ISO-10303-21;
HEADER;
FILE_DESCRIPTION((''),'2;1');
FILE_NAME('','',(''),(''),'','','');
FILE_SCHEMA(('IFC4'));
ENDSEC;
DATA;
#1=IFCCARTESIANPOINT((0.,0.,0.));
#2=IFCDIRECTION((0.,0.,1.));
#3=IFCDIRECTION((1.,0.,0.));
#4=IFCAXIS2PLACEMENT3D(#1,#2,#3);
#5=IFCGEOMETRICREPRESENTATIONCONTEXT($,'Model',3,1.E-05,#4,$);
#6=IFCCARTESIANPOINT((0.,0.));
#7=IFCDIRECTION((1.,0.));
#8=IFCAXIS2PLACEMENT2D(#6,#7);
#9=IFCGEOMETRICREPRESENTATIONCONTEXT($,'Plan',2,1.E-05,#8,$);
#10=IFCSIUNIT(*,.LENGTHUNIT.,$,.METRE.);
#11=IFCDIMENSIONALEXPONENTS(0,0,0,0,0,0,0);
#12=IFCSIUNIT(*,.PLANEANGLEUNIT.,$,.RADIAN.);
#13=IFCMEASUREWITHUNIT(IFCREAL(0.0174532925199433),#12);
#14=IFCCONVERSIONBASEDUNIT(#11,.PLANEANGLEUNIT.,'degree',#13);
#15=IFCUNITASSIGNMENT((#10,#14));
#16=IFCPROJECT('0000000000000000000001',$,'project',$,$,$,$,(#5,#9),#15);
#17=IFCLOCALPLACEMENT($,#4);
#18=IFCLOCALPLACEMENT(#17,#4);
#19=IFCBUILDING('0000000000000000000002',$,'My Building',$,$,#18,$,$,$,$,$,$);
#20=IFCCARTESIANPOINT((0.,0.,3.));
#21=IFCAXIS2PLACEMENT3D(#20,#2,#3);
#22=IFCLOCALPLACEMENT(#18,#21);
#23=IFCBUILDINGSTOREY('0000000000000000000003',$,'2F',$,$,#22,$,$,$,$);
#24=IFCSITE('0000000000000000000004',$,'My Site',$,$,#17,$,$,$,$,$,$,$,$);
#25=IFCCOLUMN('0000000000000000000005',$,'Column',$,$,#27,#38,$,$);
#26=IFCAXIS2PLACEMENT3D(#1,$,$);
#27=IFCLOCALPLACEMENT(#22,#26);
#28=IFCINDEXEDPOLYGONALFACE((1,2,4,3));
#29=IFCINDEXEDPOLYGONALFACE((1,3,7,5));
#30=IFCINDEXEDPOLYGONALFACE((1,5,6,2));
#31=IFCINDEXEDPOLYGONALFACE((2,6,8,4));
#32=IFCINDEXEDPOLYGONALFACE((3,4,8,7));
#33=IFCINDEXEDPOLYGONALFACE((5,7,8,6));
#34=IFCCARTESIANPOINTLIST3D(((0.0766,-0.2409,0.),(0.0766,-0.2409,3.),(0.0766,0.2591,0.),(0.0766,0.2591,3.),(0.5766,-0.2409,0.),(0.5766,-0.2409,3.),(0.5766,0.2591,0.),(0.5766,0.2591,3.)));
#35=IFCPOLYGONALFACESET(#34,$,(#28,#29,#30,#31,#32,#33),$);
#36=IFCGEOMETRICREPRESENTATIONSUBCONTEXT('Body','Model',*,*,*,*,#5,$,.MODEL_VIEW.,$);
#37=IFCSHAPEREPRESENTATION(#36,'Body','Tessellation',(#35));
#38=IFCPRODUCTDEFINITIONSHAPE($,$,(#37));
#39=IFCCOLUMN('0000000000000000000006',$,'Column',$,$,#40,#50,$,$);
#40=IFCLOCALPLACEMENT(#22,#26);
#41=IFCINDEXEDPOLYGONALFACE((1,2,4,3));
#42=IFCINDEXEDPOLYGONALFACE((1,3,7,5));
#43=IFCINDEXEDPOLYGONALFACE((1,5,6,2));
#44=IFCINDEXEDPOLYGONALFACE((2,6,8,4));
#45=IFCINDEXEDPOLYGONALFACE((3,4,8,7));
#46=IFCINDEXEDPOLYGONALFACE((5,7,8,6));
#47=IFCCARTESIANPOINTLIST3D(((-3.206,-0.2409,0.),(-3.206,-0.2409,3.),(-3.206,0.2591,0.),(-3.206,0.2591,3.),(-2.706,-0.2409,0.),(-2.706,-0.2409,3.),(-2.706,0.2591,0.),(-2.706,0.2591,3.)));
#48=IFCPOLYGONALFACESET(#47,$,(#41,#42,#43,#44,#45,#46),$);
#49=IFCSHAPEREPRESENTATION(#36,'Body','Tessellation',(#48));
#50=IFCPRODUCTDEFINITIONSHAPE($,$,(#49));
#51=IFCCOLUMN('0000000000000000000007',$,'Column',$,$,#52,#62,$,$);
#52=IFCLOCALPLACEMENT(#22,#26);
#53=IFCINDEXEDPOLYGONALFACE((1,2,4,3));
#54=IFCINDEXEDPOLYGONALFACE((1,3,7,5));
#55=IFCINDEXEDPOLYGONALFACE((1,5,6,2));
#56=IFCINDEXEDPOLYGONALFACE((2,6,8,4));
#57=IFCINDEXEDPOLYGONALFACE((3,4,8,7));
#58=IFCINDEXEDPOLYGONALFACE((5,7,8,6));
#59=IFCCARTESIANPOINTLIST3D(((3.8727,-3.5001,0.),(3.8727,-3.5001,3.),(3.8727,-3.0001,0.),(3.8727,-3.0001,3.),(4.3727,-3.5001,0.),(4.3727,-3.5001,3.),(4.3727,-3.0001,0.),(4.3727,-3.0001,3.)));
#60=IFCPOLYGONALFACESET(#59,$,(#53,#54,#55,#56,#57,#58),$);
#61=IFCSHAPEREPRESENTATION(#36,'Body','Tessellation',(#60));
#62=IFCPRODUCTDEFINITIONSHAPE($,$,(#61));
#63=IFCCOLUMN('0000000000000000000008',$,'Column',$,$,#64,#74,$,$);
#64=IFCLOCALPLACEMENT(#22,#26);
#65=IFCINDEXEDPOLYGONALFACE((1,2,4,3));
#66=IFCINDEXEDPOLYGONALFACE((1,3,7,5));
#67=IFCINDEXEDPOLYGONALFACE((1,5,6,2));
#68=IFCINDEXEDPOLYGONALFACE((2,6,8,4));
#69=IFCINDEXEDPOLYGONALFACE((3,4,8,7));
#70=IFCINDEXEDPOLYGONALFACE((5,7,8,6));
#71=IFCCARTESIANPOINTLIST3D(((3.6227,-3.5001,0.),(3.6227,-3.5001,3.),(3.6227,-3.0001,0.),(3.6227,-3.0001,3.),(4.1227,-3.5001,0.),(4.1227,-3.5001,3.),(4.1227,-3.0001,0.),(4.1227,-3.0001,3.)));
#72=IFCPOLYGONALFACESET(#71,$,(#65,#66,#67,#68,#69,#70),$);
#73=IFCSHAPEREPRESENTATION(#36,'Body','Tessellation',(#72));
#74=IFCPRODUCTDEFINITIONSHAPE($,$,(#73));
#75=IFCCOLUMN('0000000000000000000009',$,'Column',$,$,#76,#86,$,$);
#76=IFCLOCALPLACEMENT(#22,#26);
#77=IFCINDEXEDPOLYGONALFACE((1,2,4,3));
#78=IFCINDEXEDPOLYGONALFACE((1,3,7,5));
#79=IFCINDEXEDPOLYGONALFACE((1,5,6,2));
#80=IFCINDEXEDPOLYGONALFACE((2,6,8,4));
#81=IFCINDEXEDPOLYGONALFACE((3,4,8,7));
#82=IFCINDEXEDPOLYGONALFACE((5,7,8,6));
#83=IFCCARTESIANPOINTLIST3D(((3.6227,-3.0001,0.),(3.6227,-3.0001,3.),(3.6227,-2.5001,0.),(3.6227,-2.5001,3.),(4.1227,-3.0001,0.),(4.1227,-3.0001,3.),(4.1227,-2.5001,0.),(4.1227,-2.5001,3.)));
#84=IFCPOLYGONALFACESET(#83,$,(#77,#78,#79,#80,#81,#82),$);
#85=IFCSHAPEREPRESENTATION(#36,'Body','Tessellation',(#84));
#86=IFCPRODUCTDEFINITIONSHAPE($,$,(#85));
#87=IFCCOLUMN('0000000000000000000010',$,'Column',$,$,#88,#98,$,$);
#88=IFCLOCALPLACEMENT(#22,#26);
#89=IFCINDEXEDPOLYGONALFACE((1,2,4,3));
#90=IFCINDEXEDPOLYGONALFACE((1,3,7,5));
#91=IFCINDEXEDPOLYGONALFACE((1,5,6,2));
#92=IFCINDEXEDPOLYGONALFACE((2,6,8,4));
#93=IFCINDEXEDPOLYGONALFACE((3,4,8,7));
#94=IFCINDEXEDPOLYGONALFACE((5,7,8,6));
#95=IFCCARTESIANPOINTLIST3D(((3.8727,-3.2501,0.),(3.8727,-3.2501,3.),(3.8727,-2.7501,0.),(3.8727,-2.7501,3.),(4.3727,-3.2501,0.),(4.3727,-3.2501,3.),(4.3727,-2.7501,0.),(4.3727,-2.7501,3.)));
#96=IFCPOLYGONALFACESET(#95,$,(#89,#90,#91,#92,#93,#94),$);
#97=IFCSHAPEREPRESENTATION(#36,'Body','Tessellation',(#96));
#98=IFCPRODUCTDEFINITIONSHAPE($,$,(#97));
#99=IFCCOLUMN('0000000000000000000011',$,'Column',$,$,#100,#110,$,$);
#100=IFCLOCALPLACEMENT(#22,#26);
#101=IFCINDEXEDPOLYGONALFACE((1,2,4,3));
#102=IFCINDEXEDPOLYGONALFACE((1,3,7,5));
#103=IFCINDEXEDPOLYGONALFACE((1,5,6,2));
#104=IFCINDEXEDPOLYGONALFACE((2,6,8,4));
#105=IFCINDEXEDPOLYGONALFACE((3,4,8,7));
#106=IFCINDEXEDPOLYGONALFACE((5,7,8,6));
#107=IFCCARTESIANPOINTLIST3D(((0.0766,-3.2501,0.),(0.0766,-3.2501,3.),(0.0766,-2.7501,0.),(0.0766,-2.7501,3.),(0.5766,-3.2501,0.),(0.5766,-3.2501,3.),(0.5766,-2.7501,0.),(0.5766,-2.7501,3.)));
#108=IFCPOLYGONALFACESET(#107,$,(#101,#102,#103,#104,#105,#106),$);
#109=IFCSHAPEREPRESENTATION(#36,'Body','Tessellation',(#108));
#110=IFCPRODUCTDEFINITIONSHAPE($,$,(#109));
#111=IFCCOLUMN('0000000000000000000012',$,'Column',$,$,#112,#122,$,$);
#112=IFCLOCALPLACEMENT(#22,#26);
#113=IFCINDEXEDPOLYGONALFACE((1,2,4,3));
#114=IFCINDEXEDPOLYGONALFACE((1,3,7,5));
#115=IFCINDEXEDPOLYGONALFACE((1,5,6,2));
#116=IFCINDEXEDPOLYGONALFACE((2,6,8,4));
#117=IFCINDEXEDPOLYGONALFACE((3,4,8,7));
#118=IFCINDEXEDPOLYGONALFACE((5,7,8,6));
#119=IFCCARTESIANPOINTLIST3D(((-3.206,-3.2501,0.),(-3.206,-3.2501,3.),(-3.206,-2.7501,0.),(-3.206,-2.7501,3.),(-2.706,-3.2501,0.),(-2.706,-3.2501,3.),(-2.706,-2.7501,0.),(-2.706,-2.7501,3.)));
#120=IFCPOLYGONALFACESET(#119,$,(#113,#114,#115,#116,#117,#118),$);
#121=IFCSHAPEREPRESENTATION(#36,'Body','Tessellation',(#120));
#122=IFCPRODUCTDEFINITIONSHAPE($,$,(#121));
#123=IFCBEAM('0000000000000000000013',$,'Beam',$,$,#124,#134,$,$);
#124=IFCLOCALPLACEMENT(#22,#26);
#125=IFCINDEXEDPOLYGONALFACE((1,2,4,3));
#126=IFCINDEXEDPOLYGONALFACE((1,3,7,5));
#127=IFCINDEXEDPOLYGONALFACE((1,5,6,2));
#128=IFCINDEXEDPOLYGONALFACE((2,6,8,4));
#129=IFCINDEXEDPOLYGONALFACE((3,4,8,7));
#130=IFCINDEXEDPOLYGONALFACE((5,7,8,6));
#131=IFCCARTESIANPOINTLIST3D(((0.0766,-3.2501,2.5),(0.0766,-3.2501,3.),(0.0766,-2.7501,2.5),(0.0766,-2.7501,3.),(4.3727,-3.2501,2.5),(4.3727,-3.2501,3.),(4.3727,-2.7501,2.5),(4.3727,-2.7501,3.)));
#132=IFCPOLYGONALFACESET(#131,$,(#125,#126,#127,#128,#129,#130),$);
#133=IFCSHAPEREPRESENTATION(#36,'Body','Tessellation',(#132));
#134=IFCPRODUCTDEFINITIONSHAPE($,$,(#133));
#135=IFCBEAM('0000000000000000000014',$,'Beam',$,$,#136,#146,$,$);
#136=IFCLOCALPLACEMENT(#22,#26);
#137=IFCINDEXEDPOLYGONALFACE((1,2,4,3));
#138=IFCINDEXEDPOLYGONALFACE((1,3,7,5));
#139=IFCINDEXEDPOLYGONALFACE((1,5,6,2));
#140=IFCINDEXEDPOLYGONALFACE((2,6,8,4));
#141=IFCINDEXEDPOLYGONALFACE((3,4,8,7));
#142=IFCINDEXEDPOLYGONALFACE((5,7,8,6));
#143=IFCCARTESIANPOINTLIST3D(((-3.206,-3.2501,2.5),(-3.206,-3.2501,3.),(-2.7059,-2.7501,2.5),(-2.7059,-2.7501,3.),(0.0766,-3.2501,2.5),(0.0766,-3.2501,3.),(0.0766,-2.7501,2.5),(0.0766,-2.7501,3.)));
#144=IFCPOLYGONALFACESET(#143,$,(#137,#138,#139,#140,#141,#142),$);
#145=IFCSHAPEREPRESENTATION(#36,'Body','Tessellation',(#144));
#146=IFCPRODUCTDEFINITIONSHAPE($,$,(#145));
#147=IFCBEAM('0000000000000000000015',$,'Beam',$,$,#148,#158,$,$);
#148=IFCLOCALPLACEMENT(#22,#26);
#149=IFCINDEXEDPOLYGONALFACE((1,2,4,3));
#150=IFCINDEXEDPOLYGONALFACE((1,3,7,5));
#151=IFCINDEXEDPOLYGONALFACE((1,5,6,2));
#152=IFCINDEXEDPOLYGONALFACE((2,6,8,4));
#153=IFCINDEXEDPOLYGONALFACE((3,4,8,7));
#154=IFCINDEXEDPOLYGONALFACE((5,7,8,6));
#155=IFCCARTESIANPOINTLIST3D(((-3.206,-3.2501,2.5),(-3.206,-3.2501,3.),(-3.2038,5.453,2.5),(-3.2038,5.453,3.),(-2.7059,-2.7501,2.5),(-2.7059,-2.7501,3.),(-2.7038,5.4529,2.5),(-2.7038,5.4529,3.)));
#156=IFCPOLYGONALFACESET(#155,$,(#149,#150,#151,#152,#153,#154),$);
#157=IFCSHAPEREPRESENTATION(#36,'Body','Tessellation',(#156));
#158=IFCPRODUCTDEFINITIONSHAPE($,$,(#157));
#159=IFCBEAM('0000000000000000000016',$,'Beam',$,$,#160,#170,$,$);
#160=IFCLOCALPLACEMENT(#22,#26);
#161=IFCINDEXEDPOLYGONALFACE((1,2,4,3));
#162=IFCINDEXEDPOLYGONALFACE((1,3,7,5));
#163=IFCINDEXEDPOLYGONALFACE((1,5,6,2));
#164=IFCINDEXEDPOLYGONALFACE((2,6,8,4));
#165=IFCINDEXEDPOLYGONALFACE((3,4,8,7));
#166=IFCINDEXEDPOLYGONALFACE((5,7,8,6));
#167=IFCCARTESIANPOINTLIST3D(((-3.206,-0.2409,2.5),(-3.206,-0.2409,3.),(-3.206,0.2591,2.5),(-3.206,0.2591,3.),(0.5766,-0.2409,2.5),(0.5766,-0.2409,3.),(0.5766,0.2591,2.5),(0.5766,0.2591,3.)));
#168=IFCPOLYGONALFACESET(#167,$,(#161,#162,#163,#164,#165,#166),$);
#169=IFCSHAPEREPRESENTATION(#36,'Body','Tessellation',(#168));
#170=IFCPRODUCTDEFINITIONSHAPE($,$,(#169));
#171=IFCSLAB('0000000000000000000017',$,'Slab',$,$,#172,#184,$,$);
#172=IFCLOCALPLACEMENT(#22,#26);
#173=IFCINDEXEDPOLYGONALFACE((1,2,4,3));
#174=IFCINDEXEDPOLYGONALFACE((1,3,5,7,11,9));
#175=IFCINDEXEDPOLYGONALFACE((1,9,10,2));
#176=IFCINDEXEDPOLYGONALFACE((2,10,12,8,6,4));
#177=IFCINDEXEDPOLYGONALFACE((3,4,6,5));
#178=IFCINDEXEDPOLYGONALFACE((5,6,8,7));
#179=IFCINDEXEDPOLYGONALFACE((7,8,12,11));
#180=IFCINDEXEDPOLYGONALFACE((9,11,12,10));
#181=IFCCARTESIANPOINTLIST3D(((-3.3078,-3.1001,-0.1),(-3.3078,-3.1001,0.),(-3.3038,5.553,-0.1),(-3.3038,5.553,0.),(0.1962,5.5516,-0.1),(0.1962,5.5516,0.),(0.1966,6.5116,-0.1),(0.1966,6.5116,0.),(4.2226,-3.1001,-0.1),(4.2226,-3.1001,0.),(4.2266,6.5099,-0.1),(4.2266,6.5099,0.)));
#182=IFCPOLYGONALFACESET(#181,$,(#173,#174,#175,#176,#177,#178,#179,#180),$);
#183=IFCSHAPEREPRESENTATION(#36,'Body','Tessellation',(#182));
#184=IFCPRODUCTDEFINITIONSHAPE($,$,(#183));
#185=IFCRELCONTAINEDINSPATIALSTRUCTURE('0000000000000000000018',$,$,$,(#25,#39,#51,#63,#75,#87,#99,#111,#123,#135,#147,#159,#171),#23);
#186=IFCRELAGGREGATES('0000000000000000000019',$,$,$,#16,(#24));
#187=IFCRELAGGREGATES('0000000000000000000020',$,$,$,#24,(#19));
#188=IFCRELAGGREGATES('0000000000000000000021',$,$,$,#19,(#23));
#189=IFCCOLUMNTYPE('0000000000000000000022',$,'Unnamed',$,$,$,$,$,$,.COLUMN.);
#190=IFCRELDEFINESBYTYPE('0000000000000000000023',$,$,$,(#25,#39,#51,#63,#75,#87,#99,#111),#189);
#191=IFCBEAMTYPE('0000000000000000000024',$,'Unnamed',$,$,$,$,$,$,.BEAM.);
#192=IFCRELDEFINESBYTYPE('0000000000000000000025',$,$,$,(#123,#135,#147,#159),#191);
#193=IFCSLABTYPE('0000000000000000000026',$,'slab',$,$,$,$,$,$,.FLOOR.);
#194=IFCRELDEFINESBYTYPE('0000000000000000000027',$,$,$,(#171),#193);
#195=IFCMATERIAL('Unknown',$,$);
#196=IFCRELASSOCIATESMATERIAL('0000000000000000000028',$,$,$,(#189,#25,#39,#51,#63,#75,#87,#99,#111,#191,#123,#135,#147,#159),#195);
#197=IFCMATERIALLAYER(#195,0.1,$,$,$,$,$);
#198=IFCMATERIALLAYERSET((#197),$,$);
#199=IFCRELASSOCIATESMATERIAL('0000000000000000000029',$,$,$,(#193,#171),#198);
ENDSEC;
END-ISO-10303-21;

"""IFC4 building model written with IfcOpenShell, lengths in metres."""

from ifc_helpers import new_model, entity, si_unit, converted_unit, frame, origin_with_axes, origin_2d_with_axis, place, context, subcontext, project, spatial, indexed_curve, rectangle, outline, extrude, clip, halfspace, material, layer, layer_set, layer_usage, material_profile, profile_set, profile_usage, type_object, element, save


model = new_model("IFC4")

# Units and contexts
model_context = context("Model", 3, precision=1e-05, world=origin_with_axes())
plan_context = context("Plan", 2, precision=1e-05, world=origin_2d_with_axis())
body_context_1 = subcontext(model_context, "Body", "Model", "MODEL_VIEW")
ifc_project = project(units=[si_unit("LENGTHUNIT", "METRE"), converted_unit("PLANEANGLEUNIT", "degree", entity("IfcReal", 0.0174532925199433), si_unit("PLANEANGLEUNIT", "RADIAN"), dimensions=[0, 0, 0, 0, 0, 0, 0])], contexts=[model_context, plan_context])

# Site, building, storey
site_placement = place(None, origin_with_axes())
site = spatial("IfcSite", under=ifc_project, at=site_placement, Name="My Site")
building_placement = place(site_placement, origin_with_axes())
building = spatial("IfcBuilding", under=site, at=building_placement, Name="My Building")
storey_placement = place(building_placement, frame((0.0, 0.0, 3.0), z_axis=(0.0, 0.0, 1.0), x_axis=(1.0, 0.0, 0.0)))
storey = spatial("IfcBuildingStorey", under=building, at=storey_placement, Name="2F")

# Columns
ifc_material = material(Name="Unknown")
ifc_material_profile_1 = material_profile(ifc_material, rectangle(XDim=0.5, YDim=0.5))
ifc_profile_set_1 = profile_set([ifc_material_profile_1])
ifc_profile_usage_1 = profile_usage(ifc_profile_set_1, cardinal=9)
column_type = type_object("IfcColumnType", Name="Unnamed", PredefinedType="COLUMN", material=ifc_profile_set_1)
column_1_placement = place(storey_placement, frame((0.0766, 0.2591, 0.0), z_axis=(0.0, 0.0, 1.0), x_axis=(1.0, 0.0, 0.0)))
element("IfcColumn", 1, at=column_1_placement, inside=storey, type_object=column_type, material=ifc_profile_usage_1, Name="Column", context=body_context_1, shape_type="SweptSolid", body=[
    extrude(rectangle(XDim=0.5, YDim=0.5), frame((0.25, -0.25, 0.0), z_axis=(0.0, 0.0, 1.0), x_axis=(1.0, 0.0, 0.0)), (0.0, 0.0, 1.0), 3.0),
])
ifc_profile_usage_2 = profile_usage(ifc_profile_set_1, cardinal=9)
column_2_placement = place(storey_placement, frame((-3.206, 0.2591, 0.0), z_axis=(0.0, 0.0, 1.0), x_axis=(1.0, 0.0, 0.0)))
element("IfcColumn", 2, at=column_2_placement, inside=storey, type_object=column_type, material=ifc_profile_usage_2, Name="Column", context=body_context_1, shape_type="SweptSolid", body=[
    extrude(rectangle(XDim=0.5, YDim=0.5), frame((0.25, -0.25, 0.0), z_axis=(0.0, 0.0, 1.0), x_axis=(1.0, 0.0, 0.0)), (0.0, 0.0, 1.0), 3.0),
])
ifc_profile_usage_3 = profile_usage(ifc_profile_set_1, cardinal=8)
column_3_placement = place(storey_placement, frame((4.1227, -3.0001, 0.0), z_axis=(0.0, 0.0, 1.0), x_axis=(1.0, 0.0, 0.0)))
element("IfcColumn", 3, at=column_3_placement, inside=storey, type_object=column_type, material=ifc_profile_usage_3, Name="Column", context=body_context_1, shape_type="SweptSolid", body=[
    extrude(rectangle(XDim=0.5, YDim=0.5), frame((0.0, -0.25, 0.0), z_axis=(0.0, 0.0, 1.0), x_axis=(1.0, 0.0, 0.0)), (0.0, 0.0, 1.0), 3.0),
])
ifc_profile_usage_4 = profile_usage(ifc_profile_set_1, cardinal=7)
column_4_placement = place(storey_placement, frame((4.1227, -3.0001, 0.0), z_axis=(0.0, 0.0, 1.0), x_axis=(1.0, 0.0, 0.0)))
element("IfcColumn", 4, at=column_4_placement, inside=storey, type_object=column_type, material=ifc_profile_usage_4, Name="Column", context=body_context_1, shape_type="SweptSolid", body=[
    extrude(rectangle(XDim=0.5, YDim=0.5), frame((-0.25, -0.25, 0.0), z_axis=(0.0, 0.0, 1.0), x_axis=(1.0, 0.0, 0.0)), (0.0, 0.0, 1.0), 3.0),
])
ifc_profile_usage_5 = profile_usage(ifc_profile_set_1, cardinal=1)
column_5_placement = place(storey_placement, frame((4.1227, -3.0001, 0.0), z_axis=(0.0, 0.0, 1.0), x_axis=(1.0, 0.0, 0.0)))
element("IfcColumn", 5, at=column_5_placement, inside=storey, type_object=column_type, material=ifc_profile_usage_5, Name="Column", context=body_context_1, shape_type="SweptSolid", body=[
    extrude(rectangle(XDim=0.5, YDim=0.5), frame((-0.25, 0.25, 0.0), z_axis=(0.0, 0.0, 1.0), x_axis=(1.0, 0.0, 0.0)), (0.0, 0.0, 1.0), 3.0),
])
ifc_profile_usage_6 = profile_usage(ifc_profile_set_1, cardinal=5)
column_6_placement = place(storey_placement, frame((4.1227, -3.0001, 0.0), z_axis=(0.0, 0.0, 1.0), x_axis=(1.0, 0.0, 0.0)))
element("IfcColumn", 6, at=column_6_placement, inside=storey, type_object=column_type, material=ifc_profile_usage_6, Name="Column", context=body_context_1, shape_type="SweptSolid", body=[
    extrude(rectangle(XDim=0.5, YDim=0.5), origin_with_axes(), (0.0, 0.0, 1.0), 3.0),
])
ifc_profile_usage_7 = profile_usage(ifc_profile_set_1, cardinal=5)
column_7_placement = place(storey_placement, frame((0.3266, -3.0001, 0.0), z_axis=(0.0, 0.0, 1.0), x_axis=(1.0, 0.0, 0.0)))
element("IfcColumn", 7, at=column_7_placement, inside=storey, type_object=column_type, material=ifc_profile_usage_7, Name="Column", context=body_context_1, shape_type="SweptSolid", body=[
    extrude(rectangle(XDim=0.5, YDim=0.5), origin_with_axes(), (0.0, 0.0, 1.0), 3.0),
])
ifc_profile_usage_8 = profile_usage(ifc_profile_set_1, cardinal=5)
column_8_placement = place(storey_placement, frame((-2.956, -3.0001, 0.0), z_axis=(0.0, 0.0, 1.0), x_axis=(1.0, 0.0, 0.0)))
element("IfcColumn", 8, at=column_8_placement, inside=storey, type_object=column_type, material=ifc_profile_usage_8, Name="Column", context=body_context_1, shape_type="SweptSolid", body=[
    extrude(rectangle(XDim=0.5, YDim=0.5), origin_with_axes(), (0.0, 0.0, 1.0), 3.0),
])

# Beams
ifc_material_profile_2 = material_profile(ifc_material, rectangle(XDim=0.5, YDim=0.5))
ifc_profile_set_2 = profile_set([ifc_material_profile_2])
ifc_profile_usage_9 = profile_usage(ifc_profile_set_2, cardinal=7)
beam_type = type_object("IfcBeamType", Name="Unnamed", PredefinedType="BEAM", material=ifc_profile_set_2)
beam_1_placement = place(storey_placement, frame((4.3727, -3.2501, 3.0), z_axis=(-1.0, 0.0, 0.0), x_axis=(0.0, -1.0, 0.0)))
element("IfcBeam", 9, at=beam_1_placement, inside=storey, type_object=beam_type, material=ifc_profile_usage_9, Name="Beam", context=body_context_1, shape_type="SweptSolid", body=[
    extrude(rectangle(XDim=0.5, YDim=0.5), frame((-0.25, -0.25, 0.0), z_axis=(0.0, 0.0, 1.0), x_axis=(1.0, 0.0, 0.0)), (0.0, 0.0, 1.0), 4.2961),
])
ifc_profile_usage_10 = profile_usage(ifc_profile_set_2, cardinal=7)
beam_2_placement = place(storey_placement, frame((0.0766, -3.2501, 3.0), z_axis=(-1.0, 0.0, 0.0), x_axis=(0.0, -1.0, 0.0)))
element("IfcBeam", 10, at=beam_2_placement, inside=storey, type_object=beam_type, material=ifc_profile_usage_10, Name="Beam", context=body_context_1, shape_type="Clipping", body=[
    clip(extrude(rectangle(XDim=0.5, YDim=0.5), frame((-0.25, -0.25, 0.0), z_axis=(0.0, 0.0, 1.0), x_axis=(1.0, 0.0, 0.0)), (0.0, 0.0, 1.0), 3.7826), halfspace(frame((0.0, -6.0, 3.2826), z_axis=(-0.707196, 0.0, 0.707018), x_axis=(0.0, 1.0, 0.0)), False)),
])
ifc_profile_usage_11 = profile_usage(ifc_profile_set_2, cardinal=7)
beam_3_placement = place(storey_placement, frame((-3.2061, -3.7501, 3.0), z_axis=(0.000251, 1.0, 0.0), x_axis=(-1.0, 0.000251, 0.0)))
element("IfcBeam", 11, at=beam_3_placement, inside=storey, type_object=beam_type, material=ifc_profile_usage_11, Name="Beam", context=body_context_1, shape_type="Clipping", body=[
    clip(extrude(rectangle(XDim=0.5, YDim=0.5), frame((-0.25, -0.25, 0.0), z_axis=(0.0, 0.0, 1.0), x_axis=(1.0, 0.0, 0.0)), (0.0, 0.0, 1.0), 9.2031), halfspace(frame((0.0, -6.0, 0.5), z_axis=(-0.707196, 0.0, -0.707018), x_axis=(0.0, 1.0, 0.0)), False)),
])
ifc_profile_usage_12 = profile_usage(ifc_profile_set_2, cardinal=7)
beam_4_placement = place(storey_placement, frame((-3.206, 0.2591, 3.0), z_axis=(1.0, 0.0, 0.0), x_axis=(0.0, 1.0, 0.0)))
element("IfcBeam", 12, at=beam_4_placement, inside=storey, type_object=beam_type, material=ifc_profile_usage_12, Name="Beam", context=body_context_1, shape_type="SweptSolid", body=[
    extrude(rectangle(XDim=0.5, YDim=0.5), frame((-0.25, -0.25, 0.0), z_axis=(0.0, 0.0, 1.0), x_axis=(1.0, 0.0, 0.0)), (0.0, 0.0, 1.0), 3.7827),
])

# Slab
ifc_layer_1 = layer(ifc_material, 0.1)
ifc_layer_set_1 = layer_set([ifc_layer_1])
ifc_layer_usage_1 = layer_usage(ifc_layer_set_1, "AXIS3", "POSITIVE", -0.1)
slab_type = type_object("IfcSlabType", Name="slab", PredefinedType="FLOOR", material=ifc_layer_set_1)
slab_placement = place(storey_placement, frame((-3.3078, -3.1001, 0.0), z_axis=(0.0, 0.0, 1.0), x_axis=(1.0, 0.0, 0.0)))
element("IfcSlab", 13, at=slab_placement, inside=storey, type_object=slab_type, material=ifc_layer_usage_1, Name="Slab", context=body_context_1, shape_type="SweptSolid", body=[
    extrude(outline(indexed_curve([(0.0, 0.0), (7.5304, 0.0), (7.5344, 9.61), (3.5044, 9.6117), (3.504, 8.6517), (0.004, 8.6531), (0.0, 0.0)])), frame((0.0, 0.0, -0.1), z_axis=(0.0, 0.0, 1.0), x_axis=(1.0, 0.0, 0.0)), (0.0, 0.0, 1.0), 0.1),
])

save(model, "model.ifc")
